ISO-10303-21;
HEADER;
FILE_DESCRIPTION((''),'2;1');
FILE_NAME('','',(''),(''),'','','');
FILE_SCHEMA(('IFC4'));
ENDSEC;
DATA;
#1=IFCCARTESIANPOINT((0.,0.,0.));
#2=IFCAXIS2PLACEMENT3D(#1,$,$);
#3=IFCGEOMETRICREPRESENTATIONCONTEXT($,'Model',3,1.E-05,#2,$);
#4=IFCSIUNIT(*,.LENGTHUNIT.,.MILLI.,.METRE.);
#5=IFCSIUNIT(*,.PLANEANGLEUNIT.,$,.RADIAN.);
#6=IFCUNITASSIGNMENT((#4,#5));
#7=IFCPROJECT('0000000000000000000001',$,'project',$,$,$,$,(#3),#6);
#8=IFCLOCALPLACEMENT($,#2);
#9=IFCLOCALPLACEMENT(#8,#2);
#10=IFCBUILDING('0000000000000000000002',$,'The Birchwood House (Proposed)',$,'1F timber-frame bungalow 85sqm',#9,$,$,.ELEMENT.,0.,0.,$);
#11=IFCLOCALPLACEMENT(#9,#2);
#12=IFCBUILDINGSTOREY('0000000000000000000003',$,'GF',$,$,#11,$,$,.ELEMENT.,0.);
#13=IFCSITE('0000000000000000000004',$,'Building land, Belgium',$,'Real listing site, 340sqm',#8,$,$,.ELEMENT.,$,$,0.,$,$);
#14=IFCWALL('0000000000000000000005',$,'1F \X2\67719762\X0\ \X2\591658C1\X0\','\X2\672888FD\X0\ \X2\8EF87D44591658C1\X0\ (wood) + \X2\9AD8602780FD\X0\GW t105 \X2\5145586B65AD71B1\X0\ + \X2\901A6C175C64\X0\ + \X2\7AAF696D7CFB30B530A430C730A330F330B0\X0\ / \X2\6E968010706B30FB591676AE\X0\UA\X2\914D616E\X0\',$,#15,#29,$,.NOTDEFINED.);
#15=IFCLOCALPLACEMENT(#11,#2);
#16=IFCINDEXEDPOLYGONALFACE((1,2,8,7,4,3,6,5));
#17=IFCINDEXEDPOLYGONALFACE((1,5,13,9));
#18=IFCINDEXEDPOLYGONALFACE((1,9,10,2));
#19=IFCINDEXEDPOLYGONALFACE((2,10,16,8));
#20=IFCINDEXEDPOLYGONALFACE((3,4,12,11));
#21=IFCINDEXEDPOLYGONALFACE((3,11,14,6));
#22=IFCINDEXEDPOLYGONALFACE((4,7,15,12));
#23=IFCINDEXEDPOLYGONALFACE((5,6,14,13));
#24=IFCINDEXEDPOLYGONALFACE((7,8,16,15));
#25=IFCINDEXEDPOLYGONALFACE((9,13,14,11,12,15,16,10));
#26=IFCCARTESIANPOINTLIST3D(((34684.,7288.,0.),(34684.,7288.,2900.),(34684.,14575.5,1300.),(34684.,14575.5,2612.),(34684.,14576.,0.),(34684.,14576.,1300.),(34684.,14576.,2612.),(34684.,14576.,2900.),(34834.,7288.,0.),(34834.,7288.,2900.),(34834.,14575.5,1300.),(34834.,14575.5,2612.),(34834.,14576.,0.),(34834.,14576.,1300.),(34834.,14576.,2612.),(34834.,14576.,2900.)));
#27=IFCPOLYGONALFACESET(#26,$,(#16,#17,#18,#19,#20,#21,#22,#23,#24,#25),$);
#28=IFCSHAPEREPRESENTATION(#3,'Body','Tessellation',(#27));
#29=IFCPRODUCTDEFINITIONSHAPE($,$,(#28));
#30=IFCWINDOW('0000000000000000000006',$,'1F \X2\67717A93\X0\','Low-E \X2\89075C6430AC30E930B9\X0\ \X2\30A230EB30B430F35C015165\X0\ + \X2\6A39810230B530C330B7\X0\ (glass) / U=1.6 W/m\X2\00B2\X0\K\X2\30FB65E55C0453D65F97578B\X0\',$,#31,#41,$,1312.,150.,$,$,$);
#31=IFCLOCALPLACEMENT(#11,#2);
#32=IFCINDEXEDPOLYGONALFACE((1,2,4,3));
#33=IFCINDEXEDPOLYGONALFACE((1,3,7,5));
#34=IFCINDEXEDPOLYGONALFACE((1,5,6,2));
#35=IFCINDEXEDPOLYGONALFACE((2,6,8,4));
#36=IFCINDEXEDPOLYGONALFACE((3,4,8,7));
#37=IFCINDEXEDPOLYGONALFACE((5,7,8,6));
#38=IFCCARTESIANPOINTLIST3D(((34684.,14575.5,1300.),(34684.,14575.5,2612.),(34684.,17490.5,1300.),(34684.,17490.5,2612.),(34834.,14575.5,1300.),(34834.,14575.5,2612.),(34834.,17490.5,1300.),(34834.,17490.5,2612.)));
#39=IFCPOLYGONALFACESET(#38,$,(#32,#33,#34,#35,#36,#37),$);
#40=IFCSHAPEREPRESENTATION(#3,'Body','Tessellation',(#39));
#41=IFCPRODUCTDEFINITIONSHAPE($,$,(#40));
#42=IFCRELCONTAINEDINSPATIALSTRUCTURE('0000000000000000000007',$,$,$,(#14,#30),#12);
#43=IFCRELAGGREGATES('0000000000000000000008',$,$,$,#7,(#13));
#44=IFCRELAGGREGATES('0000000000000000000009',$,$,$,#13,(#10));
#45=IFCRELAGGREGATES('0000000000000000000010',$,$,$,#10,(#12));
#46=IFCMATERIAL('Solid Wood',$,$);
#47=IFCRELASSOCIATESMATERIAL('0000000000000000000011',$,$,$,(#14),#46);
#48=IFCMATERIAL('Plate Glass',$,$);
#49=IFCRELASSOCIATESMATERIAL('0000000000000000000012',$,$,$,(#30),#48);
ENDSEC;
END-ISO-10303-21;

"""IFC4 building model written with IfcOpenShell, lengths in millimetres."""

from ifc_helpers import new_model, si_unit, frame, frame_2d, origin, place, context, project, spatial, rectangle, extrude, material, element, fill, save


model = new_model("IFC4")

# Units and contexts
model_context = context("Model", 3, precision=1e-05, world=origin())
ifc_project = project(units=[si_unit("LENGTHUNIT", "METRE", prefix="MILLI"), si_unit("PLANEANGLEUNIT", "RADIAN")], contexts=[model_context])

# Site, building, storey
site_placement = place(None, origin())
site = spatial("IfcSite", under=ifc_project, at=site_placement, Name="Building land, Belgium", ObjectType="Real listing site, 340sqm", CompositionType="ELEMENT", RefElevation=0.0)
building_placement = place(site_placement, origin())
building = spatial("IfcBuilding", under=site, at=building_placement, Name="The Birchwood House (Proposed)", ObjectType="1F timber-frame bungalow 85sqm", CompositionType="ELEMENT", ElevationOfRefHeight=0.0, ElevationOfTerrain=0.0)
storey_placement = place(building_placement, origin())
storey = spatial("IfcBuildingStorey", under=building, at=storey_placement, Name="GF", CompositionType="ELEMENT", Elevation=0.0)

# Shared definitions
ifc_material_1 = material(Name="Solid Wood")

# Wall, opening, window
wall_1_placement = place(storey_placement, frame((17342.0, 3644.0, 0.0)))
wall_1 = element("IfcWall", 1, at=wall_1_placement, inside=storey, material=ifc_material_1, Name="1F 東面 外壁", Description="木製 軸組外壁 (wood) + 高性能GW t105 充填断熱 + 通気層 + 窯業系サイディング / 準耐火・外皮UA配慮", PredefinedType="NOTDEFINED", context=model_context, shape_type="SweptSolid", body=[
    extrude(rectangle(XDim=150.0, YDim=7288.0, at=frame_2d((75.0, 3644.0))), frame((17342.0, 3644.0, 0.0)), (0.0, 0.0, 1.0), 2900.0),
])
opening_placement = place(storey_placement, frame((17342.0, 7288.0, 650.0)))
opening = element("IfcOpeningElement", 2, at=opening_placement, cuts=wall_1, PredefinedType="NOTDEFINED", context=model_context, shape_type="SweptSolid", body=[
    extrude(rectangle(XDim=150.0, YDim=2915.0, at=frame_2d((75.0, 1457.0))), frame((17342.0, 7288.0, 650.0)), (0.0, 0.0, 1.0), 1312.0),
])
ifc_material_2 = material(Name="Plate Glass")
window_placement = place(storey_placement, frame((17342.0, 7288.0, 650.0)))
window = element("IfcWindow", 3, at=window_placement, inside=storey, material=ifc_material_2, Name="1F 東窓", Description="Low-E 複層ガラス アルゴン封入 + 樹脂サッシ (glass) / U=1.6 W/m²K・日射取得型", OverallHeight=1312.0, OverallWidth=150.0, context=model_context, shape_type="SweptSolid", body=[
    extrude(rectangle(XDim=150.0, YDim=2915.0, at=frame_2d((75.0, 1457.0))), frame((17342.0, 7288.0, 650.0)), (0.0, 0.0, 1.0), 1312.0),
])
fill(opening, window)

save(model, "model.ifc")
